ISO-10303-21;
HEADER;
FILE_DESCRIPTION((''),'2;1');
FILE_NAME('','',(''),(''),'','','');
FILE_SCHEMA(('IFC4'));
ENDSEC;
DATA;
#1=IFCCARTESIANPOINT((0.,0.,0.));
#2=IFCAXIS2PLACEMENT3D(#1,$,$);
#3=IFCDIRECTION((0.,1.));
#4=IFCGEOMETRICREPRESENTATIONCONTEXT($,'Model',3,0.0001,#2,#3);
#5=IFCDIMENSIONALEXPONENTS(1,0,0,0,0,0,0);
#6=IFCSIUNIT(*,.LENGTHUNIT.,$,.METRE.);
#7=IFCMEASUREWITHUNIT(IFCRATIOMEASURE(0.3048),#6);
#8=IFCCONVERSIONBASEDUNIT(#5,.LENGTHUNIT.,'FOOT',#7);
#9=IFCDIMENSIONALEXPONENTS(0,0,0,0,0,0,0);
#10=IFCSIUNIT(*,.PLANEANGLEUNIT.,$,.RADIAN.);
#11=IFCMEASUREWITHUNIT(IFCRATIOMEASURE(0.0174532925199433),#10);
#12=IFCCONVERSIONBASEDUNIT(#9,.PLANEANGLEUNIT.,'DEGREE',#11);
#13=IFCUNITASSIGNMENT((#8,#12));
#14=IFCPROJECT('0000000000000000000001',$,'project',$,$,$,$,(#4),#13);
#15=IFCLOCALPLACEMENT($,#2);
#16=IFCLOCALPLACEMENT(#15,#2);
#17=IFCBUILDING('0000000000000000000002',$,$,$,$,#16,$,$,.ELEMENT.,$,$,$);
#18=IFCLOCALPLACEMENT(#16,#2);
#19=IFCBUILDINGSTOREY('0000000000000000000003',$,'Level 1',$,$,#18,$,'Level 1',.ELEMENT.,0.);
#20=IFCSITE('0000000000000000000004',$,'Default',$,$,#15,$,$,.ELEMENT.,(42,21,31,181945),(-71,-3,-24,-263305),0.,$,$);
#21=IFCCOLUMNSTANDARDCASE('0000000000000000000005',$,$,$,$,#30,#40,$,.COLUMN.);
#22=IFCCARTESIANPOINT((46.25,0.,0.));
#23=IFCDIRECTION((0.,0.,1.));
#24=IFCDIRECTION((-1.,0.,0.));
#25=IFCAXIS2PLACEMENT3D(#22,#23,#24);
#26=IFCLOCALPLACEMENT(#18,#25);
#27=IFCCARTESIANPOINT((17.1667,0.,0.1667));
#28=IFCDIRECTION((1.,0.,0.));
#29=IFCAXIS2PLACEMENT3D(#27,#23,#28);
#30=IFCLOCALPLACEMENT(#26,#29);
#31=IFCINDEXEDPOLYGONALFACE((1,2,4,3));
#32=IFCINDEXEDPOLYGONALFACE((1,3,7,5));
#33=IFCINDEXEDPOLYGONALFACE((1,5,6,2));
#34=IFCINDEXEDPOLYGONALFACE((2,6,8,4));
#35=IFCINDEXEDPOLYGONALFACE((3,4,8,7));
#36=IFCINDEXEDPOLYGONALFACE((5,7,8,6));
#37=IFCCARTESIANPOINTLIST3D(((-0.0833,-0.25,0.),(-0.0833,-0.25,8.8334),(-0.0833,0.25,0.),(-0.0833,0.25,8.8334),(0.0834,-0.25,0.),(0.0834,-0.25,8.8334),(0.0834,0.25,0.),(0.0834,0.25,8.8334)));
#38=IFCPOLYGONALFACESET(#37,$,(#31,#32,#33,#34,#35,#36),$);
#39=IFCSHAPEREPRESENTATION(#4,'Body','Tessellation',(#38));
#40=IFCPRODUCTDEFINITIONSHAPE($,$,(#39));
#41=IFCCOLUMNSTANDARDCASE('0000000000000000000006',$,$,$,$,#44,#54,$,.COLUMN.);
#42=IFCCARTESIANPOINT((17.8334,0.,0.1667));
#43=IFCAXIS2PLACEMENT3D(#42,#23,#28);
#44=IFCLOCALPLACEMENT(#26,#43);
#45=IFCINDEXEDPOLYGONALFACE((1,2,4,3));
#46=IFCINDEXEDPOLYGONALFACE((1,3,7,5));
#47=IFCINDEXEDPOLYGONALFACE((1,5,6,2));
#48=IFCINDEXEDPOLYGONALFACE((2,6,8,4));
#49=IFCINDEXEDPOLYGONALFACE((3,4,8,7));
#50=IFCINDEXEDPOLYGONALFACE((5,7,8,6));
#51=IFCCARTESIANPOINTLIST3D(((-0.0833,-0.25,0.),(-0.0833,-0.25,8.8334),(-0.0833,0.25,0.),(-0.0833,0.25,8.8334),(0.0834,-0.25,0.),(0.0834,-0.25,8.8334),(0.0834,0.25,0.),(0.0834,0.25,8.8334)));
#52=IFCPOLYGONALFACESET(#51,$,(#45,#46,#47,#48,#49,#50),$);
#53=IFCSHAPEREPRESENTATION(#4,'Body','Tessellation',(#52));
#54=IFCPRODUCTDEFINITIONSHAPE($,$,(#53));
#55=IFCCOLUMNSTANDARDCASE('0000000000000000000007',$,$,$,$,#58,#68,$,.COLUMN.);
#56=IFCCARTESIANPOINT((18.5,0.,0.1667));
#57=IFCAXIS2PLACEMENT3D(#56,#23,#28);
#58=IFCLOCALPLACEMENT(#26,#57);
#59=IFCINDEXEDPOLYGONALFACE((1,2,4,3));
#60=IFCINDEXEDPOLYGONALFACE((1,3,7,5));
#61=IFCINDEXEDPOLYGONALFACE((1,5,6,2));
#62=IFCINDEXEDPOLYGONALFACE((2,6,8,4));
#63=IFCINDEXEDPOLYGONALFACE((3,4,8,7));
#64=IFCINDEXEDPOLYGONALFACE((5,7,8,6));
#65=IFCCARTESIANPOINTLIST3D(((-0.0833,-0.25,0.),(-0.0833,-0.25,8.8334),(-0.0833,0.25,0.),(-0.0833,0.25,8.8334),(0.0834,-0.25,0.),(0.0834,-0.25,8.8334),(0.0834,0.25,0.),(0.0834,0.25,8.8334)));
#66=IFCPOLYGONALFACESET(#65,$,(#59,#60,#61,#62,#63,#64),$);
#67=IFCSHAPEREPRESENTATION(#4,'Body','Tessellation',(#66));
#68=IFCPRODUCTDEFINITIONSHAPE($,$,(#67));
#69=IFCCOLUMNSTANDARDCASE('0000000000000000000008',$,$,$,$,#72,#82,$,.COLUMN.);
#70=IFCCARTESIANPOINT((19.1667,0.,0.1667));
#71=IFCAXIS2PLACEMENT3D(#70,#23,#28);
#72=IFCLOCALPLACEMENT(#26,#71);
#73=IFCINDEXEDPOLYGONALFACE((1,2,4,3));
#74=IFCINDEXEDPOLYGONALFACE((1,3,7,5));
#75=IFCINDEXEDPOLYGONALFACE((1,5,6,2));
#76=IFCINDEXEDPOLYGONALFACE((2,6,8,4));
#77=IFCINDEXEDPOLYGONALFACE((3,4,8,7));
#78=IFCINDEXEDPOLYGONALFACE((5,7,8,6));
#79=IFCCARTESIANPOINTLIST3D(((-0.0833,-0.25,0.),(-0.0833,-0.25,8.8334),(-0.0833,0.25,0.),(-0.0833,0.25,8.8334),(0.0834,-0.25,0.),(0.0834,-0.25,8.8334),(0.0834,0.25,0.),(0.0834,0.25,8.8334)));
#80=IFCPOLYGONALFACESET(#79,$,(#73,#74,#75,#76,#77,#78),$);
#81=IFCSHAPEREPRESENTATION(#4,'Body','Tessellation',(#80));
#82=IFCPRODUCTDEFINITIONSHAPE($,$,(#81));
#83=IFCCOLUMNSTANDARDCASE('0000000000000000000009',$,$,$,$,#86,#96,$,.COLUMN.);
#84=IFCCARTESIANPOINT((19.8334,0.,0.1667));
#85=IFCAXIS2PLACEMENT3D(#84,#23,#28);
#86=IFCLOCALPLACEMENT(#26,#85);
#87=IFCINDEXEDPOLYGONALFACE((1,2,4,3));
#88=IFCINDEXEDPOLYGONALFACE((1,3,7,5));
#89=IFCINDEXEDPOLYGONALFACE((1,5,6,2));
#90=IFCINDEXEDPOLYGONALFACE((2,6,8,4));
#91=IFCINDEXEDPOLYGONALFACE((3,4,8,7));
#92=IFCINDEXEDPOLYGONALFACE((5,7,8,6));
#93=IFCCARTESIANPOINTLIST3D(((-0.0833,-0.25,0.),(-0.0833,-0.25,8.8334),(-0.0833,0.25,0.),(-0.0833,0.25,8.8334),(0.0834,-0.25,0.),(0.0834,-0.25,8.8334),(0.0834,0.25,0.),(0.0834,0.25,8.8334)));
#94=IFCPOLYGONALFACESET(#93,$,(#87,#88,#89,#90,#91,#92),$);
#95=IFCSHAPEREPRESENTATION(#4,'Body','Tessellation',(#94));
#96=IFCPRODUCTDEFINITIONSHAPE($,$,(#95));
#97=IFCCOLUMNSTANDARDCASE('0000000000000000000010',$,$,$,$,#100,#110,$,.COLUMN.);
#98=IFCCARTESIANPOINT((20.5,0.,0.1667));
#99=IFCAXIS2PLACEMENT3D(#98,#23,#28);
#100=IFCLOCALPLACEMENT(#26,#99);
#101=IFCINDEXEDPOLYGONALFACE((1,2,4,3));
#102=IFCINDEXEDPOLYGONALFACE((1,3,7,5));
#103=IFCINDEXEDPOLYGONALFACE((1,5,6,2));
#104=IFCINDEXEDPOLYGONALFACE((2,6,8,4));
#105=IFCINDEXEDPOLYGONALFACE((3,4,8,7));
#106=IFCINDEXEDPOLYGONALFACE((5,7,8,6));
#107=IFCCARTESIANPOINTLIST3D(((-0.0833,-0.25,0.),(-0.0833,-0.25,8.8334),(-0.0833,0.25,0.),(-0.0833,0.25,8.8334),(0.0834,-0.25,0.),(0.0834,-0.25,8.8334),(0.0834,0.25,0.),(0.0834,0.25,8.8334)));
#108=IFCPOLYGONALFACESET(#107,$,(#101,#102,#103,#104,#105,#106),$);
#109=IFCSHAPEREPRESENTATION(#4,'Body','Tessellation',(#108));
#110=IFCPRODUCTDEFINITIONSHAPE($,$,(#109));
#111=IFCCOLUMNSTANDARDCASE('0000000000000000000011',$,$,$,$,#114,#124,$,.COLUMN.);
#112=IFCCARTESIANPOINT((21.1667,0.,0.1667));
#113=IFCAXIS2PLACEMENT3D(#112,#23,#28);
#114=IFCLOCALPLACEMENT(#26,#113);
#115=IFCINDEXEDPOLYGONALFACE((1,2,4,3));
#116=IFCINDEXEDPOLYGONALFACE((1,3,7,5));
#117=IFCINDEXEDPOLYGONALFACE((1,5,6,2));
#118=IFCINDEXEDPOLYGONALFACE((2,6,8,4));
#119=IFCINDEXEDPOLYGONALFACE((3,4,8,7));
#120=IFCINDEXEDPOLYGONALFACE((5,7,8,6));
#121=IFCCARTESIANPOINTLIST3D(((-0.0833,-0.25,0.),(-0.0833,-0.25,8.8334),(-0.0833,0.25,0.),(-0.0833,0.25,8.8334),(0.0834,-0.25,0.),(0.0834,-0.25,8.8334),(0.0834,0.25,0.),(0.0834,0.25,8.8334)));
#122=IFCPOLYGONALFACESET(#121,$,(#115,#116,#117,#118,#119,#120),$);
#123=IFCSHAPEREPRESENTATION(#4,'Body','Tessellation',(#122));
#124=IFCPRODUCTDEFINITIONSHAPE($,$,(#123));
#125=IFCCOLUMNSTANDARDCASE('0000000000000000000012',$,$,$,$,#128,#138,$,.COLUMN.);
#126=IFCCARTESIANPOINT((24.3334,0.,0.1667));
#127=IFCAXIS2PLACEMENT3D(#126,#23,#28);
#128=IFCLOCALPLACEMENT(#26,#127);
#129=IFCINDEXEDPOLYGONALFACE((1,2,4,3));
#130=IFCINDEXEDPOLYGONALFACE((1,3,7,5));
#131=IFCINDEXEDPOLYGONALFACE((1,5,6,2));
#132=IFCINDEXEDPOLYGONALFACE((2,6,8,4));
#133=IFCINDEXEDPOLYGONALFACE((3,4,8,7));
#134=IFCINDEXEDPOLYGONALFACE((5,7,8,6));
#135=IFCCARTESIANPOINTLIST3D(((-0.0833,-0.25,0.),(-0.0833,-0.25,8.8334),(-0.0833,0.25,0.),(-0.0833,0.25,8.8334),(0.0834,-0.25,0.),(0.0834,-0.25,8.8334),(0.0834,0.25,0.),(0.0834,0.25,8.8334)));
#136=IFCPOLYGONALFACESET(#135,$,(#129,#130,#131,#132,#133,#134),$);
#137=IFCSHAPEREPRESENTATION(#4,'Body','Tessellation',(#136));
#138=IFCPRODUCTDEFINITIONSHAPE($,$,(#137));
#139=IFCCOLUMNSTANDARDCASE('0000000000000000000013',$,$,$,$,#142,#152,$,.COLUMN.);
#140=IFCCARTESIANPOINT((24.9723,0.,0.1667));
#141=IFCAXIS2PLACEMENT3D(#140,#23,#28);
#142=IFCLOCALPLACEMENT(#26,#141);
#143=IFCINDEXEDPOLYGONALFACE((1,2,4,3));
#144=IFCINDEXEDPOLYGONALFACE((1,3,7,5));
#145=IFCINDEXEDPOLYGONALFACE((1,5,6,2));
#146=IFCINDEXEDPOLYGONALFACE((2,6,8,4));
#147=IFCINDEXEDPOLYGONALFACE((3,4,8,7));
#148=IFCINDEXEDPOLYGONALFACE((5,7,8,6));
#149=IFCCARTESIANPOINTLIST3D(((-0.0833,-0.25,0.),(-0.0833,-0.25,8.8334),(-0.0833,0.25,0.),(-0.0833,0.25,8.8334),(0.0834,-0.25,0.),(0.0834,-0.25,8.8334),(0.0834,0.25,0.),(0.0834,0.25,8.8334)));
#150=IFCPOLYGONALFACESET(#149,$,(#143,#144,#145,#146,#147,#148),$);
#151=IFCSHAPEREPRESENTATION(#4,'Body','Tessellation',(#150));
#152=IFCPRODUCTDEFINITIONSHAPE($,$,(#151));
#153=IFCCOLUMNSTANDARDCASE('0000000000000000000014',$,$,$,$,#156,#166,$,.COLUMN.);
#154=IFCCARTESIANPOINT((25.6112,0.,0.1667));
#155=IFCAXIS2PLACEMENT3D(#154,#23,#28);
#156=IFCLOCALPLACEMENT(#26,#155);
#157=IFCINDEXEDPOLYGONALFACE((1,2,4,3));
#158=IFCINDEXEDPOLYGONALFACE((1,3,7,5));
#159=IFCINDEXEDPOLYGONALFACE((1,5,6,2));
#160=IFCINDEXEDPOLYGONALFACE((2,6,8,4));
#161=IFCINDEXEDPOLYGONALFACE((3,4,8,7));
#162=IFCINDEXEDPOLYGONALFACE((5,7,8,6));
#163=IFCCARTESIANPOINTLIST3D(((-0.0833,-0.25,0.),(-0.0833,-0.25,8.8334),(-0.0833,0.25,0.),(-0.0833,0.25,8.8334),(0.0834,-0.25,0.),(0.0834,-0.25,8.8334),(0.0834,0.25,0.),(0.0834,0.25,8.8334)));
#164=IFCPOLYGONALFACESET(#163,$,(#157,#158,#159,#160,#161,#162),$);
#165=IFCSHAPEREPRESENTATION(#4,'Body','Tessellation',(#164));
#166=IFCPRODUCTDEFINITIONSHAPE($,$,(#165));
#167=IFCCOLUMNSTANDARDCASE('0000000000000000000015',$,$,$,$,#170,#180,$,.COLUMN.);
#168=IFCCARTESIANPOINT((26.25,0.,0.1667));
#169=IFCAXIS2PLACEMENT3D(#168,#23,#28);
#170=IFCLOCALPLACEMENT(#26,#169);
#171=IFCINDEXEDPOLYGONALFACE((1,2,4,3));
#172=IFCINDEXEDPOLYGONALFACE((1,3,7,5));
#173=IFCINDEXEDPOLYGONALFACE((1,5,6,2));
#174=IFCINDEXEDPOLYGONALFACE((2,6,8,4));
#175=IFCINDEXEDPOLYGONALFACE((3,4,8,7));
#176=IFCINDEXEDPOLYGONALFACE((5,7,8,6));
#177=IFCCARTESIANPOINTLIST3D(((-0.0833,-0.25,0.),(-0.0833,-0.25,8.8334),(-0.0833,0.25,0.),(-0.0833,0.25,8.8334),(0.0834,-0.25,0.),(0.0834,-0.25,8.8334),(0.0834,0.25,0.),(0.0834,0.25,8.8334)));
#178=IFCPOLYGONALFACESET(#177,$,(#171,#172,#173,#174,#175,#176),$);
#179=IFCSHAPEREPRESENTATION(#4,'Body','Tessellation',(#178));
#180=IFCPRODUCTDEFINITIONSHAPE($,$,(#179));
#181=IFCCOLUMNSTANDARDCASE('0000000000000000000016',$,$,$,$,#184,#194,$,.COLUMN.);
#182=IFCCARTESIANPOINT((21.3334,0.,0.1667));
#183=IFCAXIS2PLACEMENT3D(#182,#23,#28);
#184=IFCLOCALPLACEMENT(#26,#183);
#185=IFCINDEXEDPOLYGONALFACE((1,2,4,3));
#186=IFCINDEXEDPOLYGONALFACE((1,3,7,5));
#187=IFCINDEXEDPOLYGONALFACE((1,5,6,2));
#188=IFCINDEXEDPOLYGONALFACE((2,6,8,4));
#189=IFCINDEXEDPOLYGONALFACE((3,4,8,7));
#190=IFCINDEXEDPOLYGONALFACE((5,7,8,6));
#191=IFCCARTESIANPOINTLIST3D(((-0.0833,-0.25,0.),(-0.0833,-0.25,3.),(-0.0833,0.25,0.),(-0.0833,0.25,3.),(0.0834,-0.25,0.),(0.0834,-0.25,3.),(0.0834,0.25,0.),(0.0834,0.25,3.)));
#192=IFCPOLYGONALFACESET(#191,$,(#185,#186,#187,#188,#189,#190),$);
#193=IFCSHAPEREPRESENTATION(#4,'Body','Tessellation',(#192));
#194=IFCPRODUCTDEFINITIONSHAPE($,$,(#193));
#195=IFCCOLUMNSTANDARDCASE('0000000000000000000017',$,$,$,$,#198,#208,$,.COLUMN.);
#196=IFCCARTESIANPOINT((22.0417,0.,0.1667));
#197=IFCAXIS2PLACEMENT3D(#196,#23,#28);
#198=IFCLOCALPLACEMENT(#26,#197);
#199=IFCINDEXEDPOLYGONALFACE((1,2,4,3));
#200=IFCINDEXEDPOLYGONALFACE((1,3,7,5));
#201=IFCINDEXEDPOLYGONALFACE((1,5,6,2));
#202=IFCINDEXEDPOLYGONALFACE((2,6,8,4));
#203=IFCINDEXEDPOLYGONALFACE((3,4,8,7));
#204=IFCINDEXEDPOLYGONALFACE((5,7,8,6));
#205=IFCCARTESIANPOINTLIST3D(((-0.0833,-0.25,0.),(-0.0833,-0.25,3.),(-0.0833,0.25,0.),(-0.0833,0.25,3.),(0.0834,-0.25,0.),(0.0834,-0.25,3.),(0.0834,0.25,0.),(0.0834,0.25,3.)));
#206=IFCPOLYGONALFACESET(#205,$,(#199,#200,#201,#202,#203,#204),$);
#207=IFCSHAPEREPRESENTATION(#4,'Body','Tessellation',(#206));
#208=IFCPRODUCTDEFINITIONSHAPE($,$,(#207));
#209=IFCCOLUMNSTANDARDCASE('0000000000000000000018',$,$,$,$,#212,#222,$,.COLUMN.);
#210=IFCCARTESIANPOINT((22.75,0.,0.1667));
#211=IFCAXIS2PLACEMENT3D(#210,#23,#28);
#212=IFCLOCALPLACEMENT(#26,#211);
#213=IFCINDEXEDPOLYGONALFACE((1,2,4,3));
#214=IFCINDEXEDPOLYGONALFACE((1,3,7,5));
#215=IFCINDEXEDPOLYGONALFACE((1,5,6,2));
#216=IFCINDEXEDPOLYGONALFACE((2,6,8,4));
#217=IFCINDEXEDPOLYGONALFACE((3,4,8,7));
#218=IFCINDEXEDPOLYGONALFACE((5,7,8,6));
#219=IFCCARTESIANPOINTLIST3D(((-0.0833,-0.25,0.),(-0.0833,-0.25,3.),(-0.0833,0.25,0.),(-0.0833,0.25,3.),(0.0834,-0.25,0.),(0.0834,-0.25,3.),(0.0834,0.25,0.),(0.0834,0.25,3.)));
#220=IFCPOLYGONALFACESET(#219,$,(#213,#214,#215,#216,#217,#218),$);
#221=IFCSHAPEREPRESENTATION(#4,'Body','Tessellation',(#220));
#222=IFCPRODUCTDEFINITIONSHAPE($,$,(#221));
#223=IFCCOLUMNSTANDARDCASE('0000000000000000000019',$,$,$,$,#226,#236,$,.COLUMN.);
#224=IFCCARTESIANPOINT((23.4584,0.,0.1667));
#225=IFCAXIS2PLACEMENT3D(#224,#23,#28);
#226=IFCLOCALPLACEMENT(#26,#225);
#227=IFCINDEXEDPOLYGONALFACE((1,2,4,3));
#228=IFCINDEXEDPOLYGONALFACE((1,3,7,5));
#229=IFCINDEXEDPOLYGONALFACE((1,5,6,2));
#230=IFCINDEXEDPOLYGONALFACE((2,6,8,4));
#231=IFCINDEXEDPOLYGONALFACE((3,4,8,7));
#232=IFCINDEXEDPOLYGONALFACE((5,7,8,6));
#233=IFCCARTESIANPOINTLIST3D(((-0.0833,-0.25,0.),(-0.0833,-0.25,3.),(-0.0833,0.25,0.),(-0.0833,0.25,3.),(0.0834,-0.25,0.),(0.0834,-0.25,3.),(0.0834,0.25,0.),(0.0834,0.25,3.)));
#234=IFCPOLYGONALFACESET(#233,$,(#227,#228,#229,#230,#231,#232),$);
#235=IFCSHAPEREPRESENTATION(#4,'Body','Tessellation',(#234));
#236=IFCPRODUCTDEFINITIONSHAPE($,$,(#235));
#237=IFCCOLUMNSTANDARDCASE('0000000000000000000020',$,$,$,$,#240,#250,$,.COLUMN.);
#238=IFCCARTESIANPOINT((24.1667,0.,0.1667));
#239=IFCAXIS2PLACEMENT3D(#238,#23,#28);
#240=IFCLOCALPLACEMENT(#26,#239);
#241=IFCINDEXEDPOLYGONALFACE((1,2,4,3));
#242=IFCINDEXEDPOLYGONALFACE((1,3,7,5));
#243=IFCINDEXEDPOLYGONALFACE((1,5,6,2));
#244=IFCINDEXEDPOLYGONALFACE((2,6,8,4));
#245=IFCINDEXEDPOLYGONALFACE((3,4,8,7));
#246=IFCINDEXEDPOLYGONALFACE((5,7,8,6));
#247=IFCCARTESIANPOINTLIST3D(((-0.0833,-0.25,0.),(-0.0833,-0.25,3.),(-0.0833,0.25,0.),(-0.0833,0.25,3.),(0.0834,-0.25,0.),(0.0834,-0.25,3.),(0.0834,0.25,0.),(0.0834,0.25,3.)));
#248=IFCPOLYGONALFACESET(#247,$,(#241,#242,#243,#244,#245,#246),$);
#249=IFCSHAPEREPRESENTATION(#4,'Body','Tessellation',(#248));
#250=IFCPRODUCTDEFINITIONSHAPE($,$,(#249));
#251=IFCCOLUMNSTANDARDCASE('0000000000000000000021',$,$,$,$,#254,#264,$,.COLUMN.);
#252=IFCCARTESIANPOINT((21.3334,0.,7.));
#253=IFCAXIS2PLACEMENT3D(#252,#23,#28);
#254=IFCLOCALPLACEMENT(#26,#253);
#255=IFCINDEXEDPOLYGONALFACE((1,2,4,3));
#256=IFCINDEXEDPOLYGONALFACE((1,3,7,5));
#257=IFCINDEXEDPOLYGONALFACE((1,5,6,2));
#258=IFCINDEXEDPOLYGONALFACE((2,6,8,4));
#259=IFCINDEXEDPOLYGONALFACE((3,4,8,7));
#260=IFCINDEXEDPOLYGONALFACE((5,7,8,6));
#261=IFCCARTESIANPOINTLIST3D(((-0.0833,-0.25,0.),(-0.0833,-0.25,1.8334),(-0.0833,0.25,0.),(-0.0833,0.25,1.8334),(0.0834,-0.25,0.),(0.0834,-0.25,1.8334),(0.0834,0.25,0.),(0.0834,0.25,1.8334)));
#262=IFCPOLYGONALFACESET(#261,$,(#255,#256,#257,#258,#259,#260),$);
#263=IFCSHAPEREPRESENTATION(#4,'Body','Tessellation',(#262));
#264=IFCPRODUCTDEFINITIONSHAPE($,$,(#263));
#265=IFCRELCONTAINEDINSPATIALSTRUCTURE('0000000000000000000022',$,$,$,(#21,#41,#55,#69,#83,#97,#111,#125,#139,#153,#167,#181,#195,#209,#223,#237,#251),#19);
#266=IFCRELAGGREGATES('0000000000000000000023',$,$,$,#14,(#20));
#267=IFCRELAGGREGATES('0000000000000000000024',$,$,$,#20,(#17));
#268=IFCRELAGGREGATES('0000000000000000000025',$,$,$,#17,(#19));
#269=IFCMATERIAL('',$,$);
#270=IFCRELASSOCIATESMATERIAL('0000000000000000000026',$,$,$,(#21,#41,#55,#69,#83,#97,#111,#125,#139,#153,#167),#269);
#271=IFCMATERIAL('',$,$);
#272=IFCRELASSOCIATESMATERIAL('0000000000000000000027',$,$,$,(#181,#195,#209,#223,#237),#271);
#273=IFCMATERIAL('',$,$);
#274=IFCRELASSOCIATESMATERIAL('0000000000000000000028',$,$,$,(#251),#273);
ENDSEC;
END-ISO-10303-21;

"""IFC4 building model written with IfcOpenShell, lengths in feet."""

from ifc_helpers import new_model, entity, si_unit, converted_unit, direction, frame, origin, place, context, project, spatial, rectangle, extrude, material, element, save


model = new_model("IFC4")

# Units and contexts
model_context = context("Model", 3, precision=0.0001, world=origin(), true_north=direction((0.0, 1.0)))
ifc_project = project(units=[converted_unit("LENGTHUNIT", "FOOT", entity("IfcRatioMeasure", 0.3048), si_unit("LENGTHUNIT", "METRE"), dimensions=[1, 0, 0, 0, 0, 0, 0]), converted_unit("PLANEANGLEUNIT", "DEGREE", entity("IfcRatioMeasure", 0.0174532925199433), si_unit("PLANEANGLEUNIT", "RADIAN"), dimensions=[0, 0, 0, 0, 0, 0, 0])], contexts=[model_context])

# Site, building, storey
site_placement = place(None, origin())
site = spatial("IfcSite", under=ifc_project, at=site_placement, Name="Default", CompositionType="ELEMENT", RefLatitude=(42, 21, 31, 181945), RefLongitude=(-71, -3, -24, -263305), RefElevation=0.0)
building_placement = place(site_placement, origin())
building = spatial("IfcBuilding", under=site, at=building_placement, CompositionType="ELEMENT")
storey_placement = place(building_placement, origin())
storey = spatial("IfcBuildingStorey", under=building, at=storey_placement, Name="Level 1", LongName="Level 1", CompositionType="ELEMENT", Elevation=0.0)

# Columns
ifc_material_1 = material(Name="")
placement_1 = place(storey_placement, frame((46.25, 0.0, 0.0), z_axis=(0.0, 0.0, 1.0), x_axis=(-1.0, 0.0, 0.0)))
for number, where, z_axis, x_axis in (
    (1, (17.1667, 0.0, 0.1667), (0.0, 0.0, 1.0), (1.0, 0.0, 0.0)),
    (2, (17.8334, 0.0, 0.1667), (0.0, 0.0, 1.0), (1.0, 0.0, 0.0)),
    (3, (18.5, 0.0, 0.1667), (0.0, 0.0, 1.0), (1.0, 0.0, 0.0)),
    (4, (19.1667, 0.0, 0.1667), (0.0, 0.0, 1.0), (1.0, 0.0, 0.0)),
    (5, (19.8334, 0.0, 0.1667), (0.0, 0.0, 1.0), (1.0, 0.0, 0.0)),
    (6, (20.5, 0.0, 0.1667), (0.0, 0.0, 1.0), (1.0, 0.0, 0.0)),
    (7, (21.1667, 0.0, 0.1667), (0.0, 0.0, 1.0), (1.0, 0.0, 0.0)),
    (8, (24.3334, 0.0, 0.1667), (0.0, 0.0, 1.0), (1.0, 0.0, 0.0)),
    (9, (24.9723, 0.0, 0.1667), (0.0, 0.0, 1.0), (1.0, 0.0, 0.0)),
    (10, (25.6112, 0.0, 0.1667), (0.0, 0.0, 1.0), (1.0, 0.0, 0.0)),
    (11, (26.25, 0.0, 0.1667), (0.0, 0.0, 1.0), (1.0, 0.0, 0.0)),
):
    element("IfcColumnStandardCase", number, at=place(placement_1, frame(where, z_axis=z_axis, x_axis=x_axis)), inside=storey, material=ifc_material_1, PredefinedType="COLUMN", context=model_context, shape_type="SweptSolid", body=[
        extrude(rectangle(XDim=0.1667, YDim=0.5), origin(), (0.0, 0.0, 1.0), 8.8334),
    ])
ifc_material_2 = material(Name="")
for number, where, z_axis, x_axis in (
    (12, (21.3334, 0.0, 0.1667), (0.0, 0.0, 1.0), (1.0, 0.0, 0.0)),
    (13, (22.0417, 0.0, 0.1667), (0.0, 0.0, 1.0), (1.0, 0.0, 0.0)),
    (14, (22.75, 0.0, 0.1667), (0.0, 0.0, 1.0), (1.0, 0.0, 0.0)),
    (15, (23.4584, 0.0, 0.1667), (0.0, 0.0, 1.0), (1.0, 0.0, 0.0)),
    (16, (24.1667, 0.0, 0.1667), (0.0, 0.0, 1.0), (1.0, 0.0, 0.0)),
):
    element("IfcColumnStandardCase", number, at=place(placement_1, frame(where, z_axis=z_axis, x_axis=x_axis)), inside=storey, material=ifc_material_2, PredefinedType="COLUMN", context=model_context, shape_type="SweptSolid", body=[
        extrude(rectangle(XDim=0.1667, YDim=0.5), origin(), (0.0, 0.0, 1.0), 3.0),
    ])
ifc_material_3 = material(Name="")
for number, where, z_axis, x_axis in (
    (17, (21.3334, 0.0, 7.0), (0.0, 0.0, 1.0), (1.0, 0.0, 0.0)),
):
    element("IfcColumnStandardCase", number, at=place(placement_1, frame(where, z_axis=z_axis, x_axis=x_axis)), inside=storey, material=ifc_material_3, PredefinedType="COLUMN", context=model_context, shape_type="SweptSolid", body=[
        extrude(rectangle(XDim=0.1667, YDim=0.5), origin(), (0.0, 0.0, 1.0), 1.8334),
    ])

save(model, "model.ifc")
